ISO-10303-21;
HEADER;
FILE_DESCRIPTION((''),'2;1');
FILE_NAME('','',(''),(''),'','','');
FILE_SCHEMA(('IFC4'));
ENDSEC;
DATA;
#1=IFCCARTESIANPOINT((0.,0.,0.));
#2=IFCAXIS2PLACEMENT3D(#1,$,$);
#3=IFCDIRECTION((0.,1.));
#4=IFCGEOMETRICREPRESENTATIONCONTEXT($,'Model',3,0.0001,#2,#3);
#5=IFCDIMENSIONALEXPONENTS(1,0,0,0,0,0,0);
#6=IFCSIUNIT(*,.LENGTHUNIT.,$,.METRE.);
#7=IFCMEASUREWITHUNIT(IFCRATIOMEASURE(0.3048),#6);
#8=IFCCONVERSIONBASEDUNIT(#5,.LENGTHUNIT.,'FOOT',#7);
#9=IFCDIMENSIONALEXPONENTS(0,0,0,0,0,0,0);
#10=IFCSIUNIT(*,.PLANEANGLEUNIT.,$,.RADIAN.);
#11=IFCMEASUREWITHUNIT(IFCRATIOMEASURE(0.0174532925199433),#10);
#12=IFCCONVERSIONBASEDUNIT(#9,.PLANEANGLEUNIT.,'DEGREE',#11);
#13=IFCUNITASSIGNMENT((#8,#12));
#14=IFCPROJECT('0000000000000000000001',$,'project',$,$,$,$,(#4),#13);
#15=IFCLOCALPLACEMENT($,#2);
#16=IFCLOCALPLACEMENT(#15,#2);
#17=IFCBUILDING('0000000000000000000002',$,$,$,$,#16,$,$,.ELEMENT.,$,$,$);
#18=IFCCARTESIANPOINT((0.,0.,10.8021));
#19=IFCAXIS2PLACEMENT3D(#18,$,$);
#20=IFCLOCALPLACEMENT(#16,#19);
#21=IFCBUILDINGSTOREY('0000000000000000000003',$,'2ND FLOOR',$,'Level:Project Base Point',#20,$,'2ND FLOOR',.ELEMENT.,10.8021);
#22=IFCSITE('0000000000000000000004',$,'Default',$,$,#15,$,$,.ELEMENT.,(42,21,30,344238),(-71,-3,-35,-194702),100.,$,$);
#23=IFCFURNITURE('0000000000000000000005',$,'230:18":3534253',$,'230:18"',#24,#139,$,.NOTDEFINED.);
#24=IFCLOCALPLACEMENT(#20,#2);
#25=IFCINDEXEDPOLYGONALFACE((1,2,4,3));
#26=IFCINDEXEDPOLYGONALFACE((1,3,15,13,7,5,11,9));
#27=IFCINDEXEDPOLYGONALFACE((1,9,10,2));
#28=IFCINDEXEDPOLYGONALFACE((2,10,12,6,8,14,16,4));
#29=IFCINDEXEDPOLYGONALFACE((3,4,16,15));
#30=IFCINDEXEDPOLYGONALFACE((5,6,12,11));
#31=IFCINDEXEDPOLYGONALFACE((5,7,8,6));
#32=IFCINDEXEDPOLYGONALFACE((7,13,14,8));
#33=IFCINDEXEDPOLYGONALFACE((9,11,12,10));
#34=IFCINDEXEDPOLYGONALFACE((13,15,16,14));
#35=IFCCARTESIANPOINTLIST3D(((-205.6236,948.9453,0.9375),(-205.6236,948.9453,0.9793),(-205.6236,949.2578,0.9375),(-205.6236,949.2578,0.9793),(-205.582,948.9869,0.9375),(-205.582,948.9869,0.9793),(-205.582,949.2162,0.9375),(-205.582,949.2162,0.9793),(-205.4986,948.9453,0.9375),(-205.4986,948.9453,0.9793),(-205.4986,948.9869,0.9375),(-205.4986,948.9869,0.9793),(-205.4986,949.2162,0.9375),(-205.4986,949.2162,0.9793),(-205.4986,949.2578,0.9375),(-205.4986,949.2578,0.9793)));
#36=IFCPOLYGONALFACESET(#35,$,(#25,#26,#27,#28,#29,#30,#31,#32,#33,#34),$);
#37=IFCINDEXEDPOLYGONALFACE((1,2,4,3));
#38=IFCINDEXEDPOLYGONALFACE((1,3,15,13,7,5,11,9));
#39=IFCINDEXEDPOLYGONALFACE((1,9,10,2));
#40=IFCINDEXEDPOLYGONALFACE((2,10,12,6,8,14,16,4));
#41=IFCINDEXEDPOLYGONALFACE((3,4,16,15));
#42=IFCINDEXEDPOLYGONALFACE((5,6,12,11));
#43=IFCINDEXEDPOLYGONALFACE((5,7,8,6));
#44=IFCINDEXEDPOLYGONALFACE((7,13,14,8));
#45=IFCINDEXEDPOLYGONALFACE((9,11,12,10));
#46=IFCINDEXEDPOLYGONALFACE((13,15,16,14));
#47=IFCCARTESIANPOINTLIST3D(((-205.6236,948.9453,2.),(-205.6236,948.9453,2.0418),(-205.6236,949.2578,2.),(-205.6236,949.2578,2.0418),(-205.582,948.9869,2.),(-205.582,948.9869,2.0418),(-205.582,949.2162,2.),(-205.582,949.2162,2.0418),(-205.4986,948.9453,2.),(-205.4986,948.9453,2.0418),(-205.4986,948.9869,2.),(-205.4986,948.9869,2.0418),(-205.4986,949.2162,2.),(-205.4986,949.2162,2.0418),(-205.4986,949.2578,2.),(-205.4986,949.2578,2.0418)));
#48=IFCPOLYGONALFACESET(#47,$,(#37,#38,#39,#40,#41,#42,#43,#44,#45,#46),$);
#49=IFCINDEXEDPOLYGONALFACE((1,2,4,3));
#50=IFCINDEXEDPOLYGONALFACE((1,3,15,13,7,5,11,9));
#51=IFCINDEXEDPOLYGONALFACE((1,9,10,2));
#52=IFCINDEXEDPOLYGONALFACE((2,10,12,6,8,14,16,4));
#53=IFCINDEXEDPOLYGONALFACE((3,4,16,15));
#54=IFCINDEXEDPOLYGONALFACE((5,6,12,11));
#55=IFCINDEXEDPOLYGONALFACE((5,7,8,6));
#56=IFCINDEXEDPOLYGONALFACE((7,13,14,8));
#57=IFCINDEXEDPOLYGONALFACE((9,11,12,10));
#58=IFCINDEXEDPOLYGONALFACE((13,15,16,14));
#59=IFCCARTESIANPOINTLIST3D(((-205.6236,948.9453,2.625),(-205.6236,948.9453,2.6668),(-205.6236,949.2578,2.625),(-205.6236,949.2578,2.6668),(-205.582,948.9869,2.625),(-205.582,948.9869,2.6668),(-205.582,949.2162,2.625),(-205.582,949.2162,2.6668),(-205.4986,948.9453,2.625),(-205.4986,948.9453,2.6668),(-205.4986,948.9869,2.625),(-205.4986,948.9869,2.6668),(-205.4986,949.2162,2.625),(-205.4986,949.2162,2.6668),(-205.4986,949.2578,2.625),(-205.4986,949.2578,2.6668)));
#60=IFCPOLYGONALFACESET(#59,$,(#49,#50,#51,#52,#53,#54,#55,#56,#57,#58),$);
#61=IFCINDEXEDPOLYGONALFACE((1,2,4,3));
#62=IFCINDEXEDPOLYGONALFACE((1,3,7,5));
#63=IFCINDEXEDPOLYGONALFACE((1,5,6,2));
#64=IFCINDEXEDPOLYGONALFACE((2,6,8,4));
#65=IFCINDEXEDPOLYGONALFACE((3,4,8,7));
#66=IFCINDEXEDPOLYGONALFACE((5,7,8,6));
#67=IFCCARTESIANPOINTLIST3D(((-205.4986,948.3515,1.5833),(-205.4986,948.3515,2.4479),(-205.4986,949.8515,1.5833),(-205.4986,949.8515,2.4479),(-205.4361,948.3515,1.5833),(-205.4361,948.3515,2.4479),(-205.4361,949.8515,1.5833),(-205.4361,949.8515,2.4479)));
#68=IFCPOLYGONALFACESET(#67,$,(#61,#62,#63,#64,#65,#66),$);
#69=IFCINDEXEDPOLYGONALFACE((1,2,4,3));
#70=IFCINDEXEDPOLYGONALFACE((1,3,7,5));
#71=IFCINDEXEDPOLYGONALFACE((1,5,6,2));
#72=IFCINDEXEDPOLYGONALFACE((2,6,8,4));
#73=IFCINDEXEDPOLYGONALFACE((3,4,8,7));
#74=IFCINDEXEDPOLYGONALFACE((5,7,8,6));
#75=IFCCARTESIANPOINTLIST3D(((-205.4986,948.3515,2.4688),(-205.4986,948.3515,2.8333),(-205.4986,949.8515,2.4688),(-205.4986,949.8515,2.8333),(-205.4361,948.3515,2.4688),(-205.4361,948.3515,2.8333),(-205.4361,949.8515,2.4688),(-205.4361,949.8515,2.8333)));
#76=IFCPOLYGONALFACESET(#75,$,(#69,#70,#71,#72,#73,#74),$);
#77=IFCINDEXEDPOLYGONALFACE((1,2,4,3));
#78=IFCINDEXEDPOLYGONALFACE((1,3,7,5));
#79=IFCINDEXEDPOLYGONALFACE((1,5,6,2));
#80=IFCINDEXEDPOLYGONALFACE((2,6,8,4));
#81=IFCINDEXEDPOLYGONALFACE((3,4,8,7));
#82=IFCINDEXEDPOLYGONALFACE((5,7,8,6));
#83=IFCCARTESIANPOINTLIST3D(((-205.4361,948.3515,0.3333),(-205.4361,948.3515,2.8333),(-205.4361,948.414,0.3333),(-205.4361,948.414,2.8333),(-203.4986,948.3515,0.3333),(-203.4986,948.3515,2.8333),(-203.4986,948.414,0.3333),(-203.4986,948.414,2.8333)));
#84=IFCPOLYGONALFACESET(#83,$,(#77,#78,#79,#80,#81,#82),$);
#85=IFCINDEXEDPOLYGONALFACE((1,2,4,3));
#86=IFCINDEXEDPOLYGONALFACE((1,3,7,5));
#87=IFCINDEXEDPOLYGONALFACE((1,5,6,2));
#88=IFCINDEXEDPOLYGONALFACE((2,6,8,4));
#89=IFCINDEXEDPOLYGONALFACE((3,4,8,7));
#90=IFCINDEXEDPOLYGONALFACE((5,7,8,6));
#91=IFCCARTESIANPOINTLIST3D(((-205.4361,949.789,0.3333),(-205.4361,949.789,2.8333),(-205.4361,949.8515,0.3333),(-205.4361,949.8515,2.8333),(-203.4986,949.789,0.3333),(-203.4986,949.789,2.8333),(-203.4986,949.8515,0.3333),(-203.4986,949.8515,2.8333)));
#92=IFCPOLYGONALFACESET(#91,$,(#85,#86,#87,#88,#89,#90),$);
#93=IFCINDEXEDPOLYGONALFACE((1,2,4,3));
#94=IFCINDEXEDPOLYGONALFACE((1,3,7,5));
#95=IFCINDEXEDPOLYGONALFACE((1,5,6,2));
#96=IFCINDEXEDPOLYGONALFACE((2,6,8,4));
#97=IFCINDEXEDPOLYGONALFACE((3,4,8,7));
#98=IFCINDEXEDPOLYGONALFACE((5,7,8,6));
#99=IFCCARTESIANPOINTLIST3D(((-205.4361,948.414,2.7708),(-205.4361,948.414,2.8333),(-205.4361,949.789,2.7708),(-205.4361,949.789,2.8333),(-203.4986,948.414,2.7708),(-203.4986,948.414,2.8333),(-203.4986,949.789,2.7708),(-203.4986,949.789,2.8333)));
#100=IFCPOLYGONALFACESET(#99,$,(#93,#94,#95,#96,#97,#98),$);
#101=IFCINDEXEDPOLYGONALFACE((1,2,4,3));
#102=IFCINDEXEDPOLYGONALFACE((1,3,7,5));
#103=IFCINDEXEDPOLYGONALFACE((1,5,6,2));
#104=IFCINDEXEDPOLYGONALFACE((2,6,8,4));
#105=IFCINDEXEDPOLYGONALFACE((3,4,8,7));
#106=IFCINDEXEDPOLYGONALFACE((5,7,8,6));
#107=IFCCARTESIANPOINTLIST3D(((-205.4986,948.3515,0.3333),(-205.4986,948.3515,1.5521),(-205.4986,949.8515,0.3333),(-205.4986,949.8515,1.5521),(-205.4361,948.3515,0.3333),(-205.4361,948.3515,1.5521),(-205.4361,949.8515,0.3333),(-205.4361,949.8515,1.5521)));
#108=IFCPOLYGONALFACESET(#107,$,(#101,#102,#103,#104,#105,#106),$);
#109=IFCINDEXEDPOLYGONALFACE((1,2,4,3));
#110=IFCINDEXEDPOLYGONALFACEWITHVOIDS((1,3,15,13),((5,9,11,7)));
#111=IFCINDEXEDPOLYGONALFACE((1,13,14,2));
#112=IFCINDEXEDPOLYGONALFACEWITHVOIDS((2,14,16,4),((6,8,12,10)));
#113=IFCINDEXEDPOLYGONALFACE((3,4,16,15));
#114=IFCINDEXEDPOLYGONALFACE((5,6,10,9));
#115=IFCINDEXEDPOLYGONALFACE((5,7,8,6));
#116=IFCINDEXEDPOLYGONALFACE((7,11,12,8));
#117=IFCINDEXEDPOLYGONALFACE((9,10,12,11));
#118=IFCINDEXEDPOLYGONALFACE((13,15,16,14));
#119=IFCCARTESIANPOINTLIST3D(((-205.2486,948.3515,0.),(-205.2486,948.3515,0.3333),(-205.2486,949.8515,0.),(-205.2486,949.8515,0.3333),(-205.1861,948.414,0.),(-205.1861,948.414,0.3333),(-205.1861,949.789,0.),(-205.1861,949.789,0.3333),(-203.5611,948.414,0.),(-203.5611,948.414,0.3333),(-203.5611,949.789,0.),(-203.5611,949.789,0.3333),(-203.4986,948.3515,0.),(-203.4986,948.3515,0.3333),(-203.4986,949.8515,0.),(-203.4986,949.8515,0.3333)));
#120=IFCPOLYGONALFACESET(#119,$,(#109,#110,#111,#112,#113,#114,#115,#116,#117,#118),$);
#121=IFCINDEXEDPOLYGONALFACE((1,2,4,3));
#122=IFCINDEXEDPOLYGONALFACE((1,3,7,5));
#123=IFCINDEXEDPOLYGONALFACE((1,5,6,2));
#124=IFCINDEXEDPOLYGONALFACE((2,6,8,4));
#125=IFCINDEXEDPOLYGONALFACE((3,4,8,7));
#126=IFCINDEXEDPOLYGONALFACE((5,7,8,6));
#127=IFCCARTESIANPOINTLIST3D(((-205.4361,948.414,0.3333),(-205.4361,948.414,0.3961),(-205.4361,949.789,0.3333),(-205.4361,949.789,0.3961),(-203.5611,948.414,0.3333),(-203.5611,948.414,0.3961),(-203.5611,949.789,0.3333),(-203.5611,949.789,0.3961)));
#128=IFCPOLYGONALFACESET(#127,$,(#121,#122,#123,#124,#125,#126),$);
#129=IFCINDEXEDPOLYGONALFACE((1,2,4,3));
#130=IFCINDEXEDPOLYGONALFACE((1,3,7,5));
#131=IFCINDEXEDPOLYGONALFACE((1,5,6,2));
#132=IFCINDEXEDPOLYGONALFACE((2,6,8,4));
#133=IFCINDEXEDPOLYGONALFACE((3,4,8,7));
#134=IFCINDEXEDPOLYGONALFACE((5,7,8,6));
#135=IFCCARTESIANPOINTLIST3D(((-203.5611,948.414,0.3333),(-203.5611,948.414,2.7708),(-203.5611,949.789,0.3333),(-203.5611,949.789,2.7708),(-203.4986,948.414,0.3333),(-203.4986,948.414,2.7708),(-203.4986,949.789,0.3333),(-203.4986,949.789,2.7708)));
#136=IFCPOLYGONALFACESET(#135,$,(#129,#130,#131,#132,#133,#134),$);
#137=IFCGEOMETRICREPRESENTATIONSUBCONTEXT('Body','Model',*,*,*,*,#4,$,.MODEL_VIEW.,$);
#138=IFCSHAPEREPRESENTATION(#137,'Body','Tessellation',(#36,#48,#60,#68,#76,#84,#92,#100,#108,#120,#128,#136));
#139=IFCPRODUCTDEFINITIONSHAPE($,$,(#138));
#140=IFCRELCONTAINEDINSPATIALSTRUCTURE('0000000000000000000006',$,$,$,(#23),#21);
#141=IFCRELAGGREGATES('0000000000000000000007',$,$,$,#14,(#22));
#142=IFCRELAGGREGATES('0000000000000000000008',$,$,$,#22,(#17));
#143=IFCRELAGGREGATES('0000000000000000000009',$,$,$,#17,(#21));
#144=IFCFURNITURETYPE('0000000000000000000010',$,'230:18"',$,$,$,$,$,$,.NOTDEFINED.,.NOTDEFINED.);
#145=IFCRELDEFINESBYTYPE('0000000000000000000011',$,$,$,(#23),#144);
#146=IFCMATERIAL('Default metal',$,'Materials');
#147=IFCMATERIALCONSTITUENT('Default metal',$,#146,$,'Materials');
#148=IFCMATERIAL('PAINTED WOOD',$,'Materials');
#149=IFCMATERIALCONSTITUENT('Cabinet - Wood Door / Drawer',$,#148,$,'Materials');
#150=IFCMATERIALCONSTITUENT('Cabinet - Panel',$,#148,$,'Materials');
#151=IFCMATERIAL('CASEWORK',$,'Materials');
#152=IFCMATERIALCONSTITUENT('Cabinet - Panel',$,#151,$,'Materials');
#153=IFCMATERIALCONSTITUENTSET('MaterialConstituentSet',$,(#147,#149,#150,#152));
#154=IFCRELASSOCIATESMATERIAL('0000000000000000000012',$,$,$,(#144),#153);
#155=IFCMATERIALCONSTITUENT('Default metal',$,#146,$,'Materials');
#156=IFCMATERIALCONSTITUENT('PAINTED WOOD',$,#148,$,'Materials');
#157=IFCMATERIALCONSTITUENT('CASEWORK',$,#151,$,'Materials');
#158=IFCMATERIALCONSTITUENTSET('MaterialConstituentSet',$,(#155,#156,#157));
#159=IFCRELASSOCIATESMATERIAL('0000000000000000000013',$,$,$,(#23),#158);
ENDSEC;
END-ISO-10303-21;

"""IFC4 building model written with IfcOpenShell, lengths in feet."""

from ifc_helpers import new_model, entity, si_unit, converted_unit, direction, frame, frame_2d, origin, origin_2d_with_axis, place, context, subcontext, project, spatial, polyline, rectangle, outline, extrude, source, transform, mapped, material, constituent, constituent_set, type_object, type_shapes, element, save


model = new_model("IFC4")

# Units and contexts
model_context = context("Model", 3, precision=0.0001, world=origin(), true_north=direction((0.0, 1.0)))
body_context = subcontext(model_context, "Body", "Model", "MODEL_VIEW")
ifc_project = project(units=[converted_unit("LENGTHUNIT", "FOOT", entity("IfcRatioMeasure", 0.3048), si_unit("LENGTHUNIT", "METRE"), dimensions=[1, 0, 0, 0, 0, 0, 0]), converted_unit("PLANEANGLEUNIT", "DEGREE", entity("IfcRatioMeasure", 0.0174532925199433), si_unit("PLANEANGLEUNIT", "RADIAN"), dimensions=[0, 0, 0, 0, 0, 0, 0])], contexts=[model_context])

# Site, building, storey
site_placement = place(None, origin())
site = spatial("IfcSite", under=ifc_project, at=site_placement, Name="Default", CompositionType="ELEMENT", RefLatitude=(42, 21, 30, 344238), RefLongitude=(-71, -3, -35, -194702), RefElevation=100.0)
building_placement = place(site_placement, origin())
building = spatial("IfcBuilding", under=site, at=building_placement, CompositionType="ELEMENT")
storey_placement = place(building_placement, frame((0.0, 0.0, 10.8021)))
storey = spatial("IfcBuildingStorey", under=building, at=storey_placement, Name="2ND FLOOR", ObjectType="Level:Project Base Point", LongName="2ND FLOOR", CompositionType="ELEMENT", Elevation=10.8021)

# Furniture
ifc_material_1 = material(Name="CASEWORK", Category="Materials")
ifc_material_2 = material(Name="PAINTED WOOD", Category="Materials")
ifc_material_3 = material(Name="Default metal", Category="Materials")
ifc_constituent_1 = constituent(ifc_material_3, Name="Default metal", Category="Materials")
ifc_constituent_2 = constituent(ifc_material_2, Name="Cabinet - Wood Door / Drawer", Category="Materials")
ifc_constituent_3 = constituent(ifc_material_2, Name="Cabinet - Panel", Category="Materials")
ifc_constituent_4 = constituent(ifc_material_1, Name="Cabinet - Panel", Category="Materials")
ifc_constituent_set_1 = constituent_set(constituents=[ifc_constituent_1, ifc_constituent_2, ifc_constituent_3, ifc_constituent_4], Name="MaterialConstituentSet")
furniture_type_1 = type_object("IfcFurnitureType", Name="230:18\"", AssemblyPlace="NOTDEFINED", PredefinedType="NOTDEFINED", material=ifc_constituent_set_1)
shared_shape_1 = source(origin(), body_context, "Body", "SweptSolid", [
    extrude(outline(polyline([(-0.1562, -0.0521), (-0.1146, -0.0521), (-0.1146, 0.0313), (0.1146, 0.0313), (0.1146, -0.0521), (0.1562, -0.0521), (0.1562, 0.0729), (-0.1562, 0.0729), (-0.1562, -0.0521)])), frame((0.0615, 2.0521, 0.9375)), (0.0, 0.0, 1.0), 0.0418),
    extrude(outline(polyline([(-0.1562, -0.0521), (-0.1146, -0.0521), (-0.1146, 0.0313), (0.1146, 0.0313), (0.1146, -0.0521), (0.1562, -0.0521), (0.1562, 0.0729), (-0.1562, 0.0729), (-0.1562, -0.0521)])), frame((0.0615, 2.0521, 2.0)), (0.0, 0.0, 1.0), 0.0418),
    extrude(outline(polyline([(-0.1562, -0.0521), (-0.1146, -0.0521), (-0.1146, 0.0313), (0.1146, 0.0313), (0.1146, -0.0521), (0.1562, -0.0521), (0.1562, 0.0729), (-0.1562, 0.0729), (-0.1562, -0.0521)])), frame((0.0615, 2.0521, 2.625)), (0.0, 0.0, 1.0), 0.0418),
    extrude(rectangle(XDim=1.5, YDim=0.0625, at=frame_2d((0.0, 0.0), x_axis=(1.0, 0.0))), frame((0.0615, 1.9688, 1.5833), z_axis=(0.0, 0.0, 1.0), x_axis=(-1.0, 0.0, 0.0)), (0.0, 0.0, 1.0), 0.8646),
    extrude(rectangle(XDim=1.5, YDim=0.0625, at=frame_2d((0.0, 0.0), x_axis=(1.0, 0.0))), frame((0.0615, 1.9688, 2.4688), z_axis=(0.0, 0.0, 1.0), x_axis=(-1.0, 0.0, 0.0)), (0.0, 0.0, 1.0), 0.3646),
    extrude(rectangle(XDim=1.9375, YDim=0.0625, at=frame_2d((0.0, 0.0), x_axis=(1.0, 0.0))), frame((-0.6573, 0.9687, 0.3333), z_axis=(0.0, 0.0, 1.0), x_axis=(0.0, -1.0, 0.0)), (0.0, 0.0, 1.0), 2.5),
    extrude(rectangle(XDim=1.9375, YDim=0.0625, at=frame_2d((0.0, 0.0), x_axis=(1.0, 0.0))), frame((0.7802, 0.9687, 0.3333), z_axis=(0.0, 0.0, 1.0), x_axis=(0.0, -1.0, 0.0)), (0.0, 0.0, 1.0), 2.5),
    extrude(rectangle(XDim=1.9375, YDim=1.375, at=origin_2d_with_axis()), frame((0.0615, 0.9687, 2.7708), z_axis=(0.0, 0.0, 1.0), x_axis=(0.0, 1.0, 0.0)), (0.0, 0.0, 1.0), 0.0625),
    extrude(rectangle(XDim=1.5, YDim=0.0625, at=frame_2d((0.0, 0.0), x_axis=(1.0, 0.0))), frame((0.0615, 1.9688, 0.3333), z_axis=(0.0, 0.0, 1.0), x_axis=(-1.0, 0.0, 0.0)), (0.0, 0.0, 1.0), 1.2187),
    extrude(outline(polyline([(-0.875, -0.75), (0.875, -0.75), (0.875, 0.75), (-0.875, 0.75), (-0.875, -0.75)]), holes=[polyline([(-0.8125, -0.6875), (-0.8125, 0.6875), (0.8125, 0.6875), (0.8125, -0.6875), (-0.8125, -0.6875)])]), frame((0.0615, 0.875, 0.0), z_axis=(0.0, 0.0, 1.0), x_axis=(0.0, -1.0, 0.0)), (0.0, 0.0, 1.0), 0.3333),
    extrude(rectangle(XDim=1.875, YDim=1.375, at=origin_2d_with_axis()), frame((0.0615, 1.0, 0.3333), z_axis=(0.0, 0.0, 1.0), x_axis=(0.0, 1.0, 0.0)), (0.0, 0.0, 1.0), 0.0627),
    extrude(rectangle(XDim=1.375, YDim=0.0625, at=origin_2d_with_axis()), frame((0.0615, 0.0312, 0.3333), z_axis=(0.0, 0.0, 1.0), x_axis=(-1.0, 0.0, 0.0)), (0.0, 0.0, 1.0), 2.4375),
])
type_shapes(furniture_type_1, [shared_shape_1])
ifc_constituent_5 = constituent(ifc_material_3, Name="Default metal", Category="Materials")
ifc_constituent_6 = constituent(ifc_material_2, Name="PAINTED WOOD", Category="Materials")
ifc_constituent_7 = constituent(ifc_material_1, Name="CASEWORK", Category="Materials")
ifc_constituent_set_2 = constituent_set(constituents=[ifc_constituent_5, ifc_constituent_6, ifc_constituent_7], Name="MaterialConstituentSet")
furniture_1_placement = place(storey_placement, frame((-203.4986, 949.04, 0.0), z_axis=(0.0, 0.0, 1.0), x_axis=(0.0, 1.0, 0.0)))
element("IfcFurniture", 1, at=furniture_1_placement, inside=storey, type_object=furniture_type_1, material=ifc_constituent_set_2, Name="230:18\":3534253", ObjectType="230:18\"", PredefinedType="NOTDEFINED", context=body_context, shape_type="MappedRepresentation", body=[
    mapped(shared_shape_1, transform((0.0, 0.0, 0.0), scale=1.0)),
])

save(model, "model.ifc")
